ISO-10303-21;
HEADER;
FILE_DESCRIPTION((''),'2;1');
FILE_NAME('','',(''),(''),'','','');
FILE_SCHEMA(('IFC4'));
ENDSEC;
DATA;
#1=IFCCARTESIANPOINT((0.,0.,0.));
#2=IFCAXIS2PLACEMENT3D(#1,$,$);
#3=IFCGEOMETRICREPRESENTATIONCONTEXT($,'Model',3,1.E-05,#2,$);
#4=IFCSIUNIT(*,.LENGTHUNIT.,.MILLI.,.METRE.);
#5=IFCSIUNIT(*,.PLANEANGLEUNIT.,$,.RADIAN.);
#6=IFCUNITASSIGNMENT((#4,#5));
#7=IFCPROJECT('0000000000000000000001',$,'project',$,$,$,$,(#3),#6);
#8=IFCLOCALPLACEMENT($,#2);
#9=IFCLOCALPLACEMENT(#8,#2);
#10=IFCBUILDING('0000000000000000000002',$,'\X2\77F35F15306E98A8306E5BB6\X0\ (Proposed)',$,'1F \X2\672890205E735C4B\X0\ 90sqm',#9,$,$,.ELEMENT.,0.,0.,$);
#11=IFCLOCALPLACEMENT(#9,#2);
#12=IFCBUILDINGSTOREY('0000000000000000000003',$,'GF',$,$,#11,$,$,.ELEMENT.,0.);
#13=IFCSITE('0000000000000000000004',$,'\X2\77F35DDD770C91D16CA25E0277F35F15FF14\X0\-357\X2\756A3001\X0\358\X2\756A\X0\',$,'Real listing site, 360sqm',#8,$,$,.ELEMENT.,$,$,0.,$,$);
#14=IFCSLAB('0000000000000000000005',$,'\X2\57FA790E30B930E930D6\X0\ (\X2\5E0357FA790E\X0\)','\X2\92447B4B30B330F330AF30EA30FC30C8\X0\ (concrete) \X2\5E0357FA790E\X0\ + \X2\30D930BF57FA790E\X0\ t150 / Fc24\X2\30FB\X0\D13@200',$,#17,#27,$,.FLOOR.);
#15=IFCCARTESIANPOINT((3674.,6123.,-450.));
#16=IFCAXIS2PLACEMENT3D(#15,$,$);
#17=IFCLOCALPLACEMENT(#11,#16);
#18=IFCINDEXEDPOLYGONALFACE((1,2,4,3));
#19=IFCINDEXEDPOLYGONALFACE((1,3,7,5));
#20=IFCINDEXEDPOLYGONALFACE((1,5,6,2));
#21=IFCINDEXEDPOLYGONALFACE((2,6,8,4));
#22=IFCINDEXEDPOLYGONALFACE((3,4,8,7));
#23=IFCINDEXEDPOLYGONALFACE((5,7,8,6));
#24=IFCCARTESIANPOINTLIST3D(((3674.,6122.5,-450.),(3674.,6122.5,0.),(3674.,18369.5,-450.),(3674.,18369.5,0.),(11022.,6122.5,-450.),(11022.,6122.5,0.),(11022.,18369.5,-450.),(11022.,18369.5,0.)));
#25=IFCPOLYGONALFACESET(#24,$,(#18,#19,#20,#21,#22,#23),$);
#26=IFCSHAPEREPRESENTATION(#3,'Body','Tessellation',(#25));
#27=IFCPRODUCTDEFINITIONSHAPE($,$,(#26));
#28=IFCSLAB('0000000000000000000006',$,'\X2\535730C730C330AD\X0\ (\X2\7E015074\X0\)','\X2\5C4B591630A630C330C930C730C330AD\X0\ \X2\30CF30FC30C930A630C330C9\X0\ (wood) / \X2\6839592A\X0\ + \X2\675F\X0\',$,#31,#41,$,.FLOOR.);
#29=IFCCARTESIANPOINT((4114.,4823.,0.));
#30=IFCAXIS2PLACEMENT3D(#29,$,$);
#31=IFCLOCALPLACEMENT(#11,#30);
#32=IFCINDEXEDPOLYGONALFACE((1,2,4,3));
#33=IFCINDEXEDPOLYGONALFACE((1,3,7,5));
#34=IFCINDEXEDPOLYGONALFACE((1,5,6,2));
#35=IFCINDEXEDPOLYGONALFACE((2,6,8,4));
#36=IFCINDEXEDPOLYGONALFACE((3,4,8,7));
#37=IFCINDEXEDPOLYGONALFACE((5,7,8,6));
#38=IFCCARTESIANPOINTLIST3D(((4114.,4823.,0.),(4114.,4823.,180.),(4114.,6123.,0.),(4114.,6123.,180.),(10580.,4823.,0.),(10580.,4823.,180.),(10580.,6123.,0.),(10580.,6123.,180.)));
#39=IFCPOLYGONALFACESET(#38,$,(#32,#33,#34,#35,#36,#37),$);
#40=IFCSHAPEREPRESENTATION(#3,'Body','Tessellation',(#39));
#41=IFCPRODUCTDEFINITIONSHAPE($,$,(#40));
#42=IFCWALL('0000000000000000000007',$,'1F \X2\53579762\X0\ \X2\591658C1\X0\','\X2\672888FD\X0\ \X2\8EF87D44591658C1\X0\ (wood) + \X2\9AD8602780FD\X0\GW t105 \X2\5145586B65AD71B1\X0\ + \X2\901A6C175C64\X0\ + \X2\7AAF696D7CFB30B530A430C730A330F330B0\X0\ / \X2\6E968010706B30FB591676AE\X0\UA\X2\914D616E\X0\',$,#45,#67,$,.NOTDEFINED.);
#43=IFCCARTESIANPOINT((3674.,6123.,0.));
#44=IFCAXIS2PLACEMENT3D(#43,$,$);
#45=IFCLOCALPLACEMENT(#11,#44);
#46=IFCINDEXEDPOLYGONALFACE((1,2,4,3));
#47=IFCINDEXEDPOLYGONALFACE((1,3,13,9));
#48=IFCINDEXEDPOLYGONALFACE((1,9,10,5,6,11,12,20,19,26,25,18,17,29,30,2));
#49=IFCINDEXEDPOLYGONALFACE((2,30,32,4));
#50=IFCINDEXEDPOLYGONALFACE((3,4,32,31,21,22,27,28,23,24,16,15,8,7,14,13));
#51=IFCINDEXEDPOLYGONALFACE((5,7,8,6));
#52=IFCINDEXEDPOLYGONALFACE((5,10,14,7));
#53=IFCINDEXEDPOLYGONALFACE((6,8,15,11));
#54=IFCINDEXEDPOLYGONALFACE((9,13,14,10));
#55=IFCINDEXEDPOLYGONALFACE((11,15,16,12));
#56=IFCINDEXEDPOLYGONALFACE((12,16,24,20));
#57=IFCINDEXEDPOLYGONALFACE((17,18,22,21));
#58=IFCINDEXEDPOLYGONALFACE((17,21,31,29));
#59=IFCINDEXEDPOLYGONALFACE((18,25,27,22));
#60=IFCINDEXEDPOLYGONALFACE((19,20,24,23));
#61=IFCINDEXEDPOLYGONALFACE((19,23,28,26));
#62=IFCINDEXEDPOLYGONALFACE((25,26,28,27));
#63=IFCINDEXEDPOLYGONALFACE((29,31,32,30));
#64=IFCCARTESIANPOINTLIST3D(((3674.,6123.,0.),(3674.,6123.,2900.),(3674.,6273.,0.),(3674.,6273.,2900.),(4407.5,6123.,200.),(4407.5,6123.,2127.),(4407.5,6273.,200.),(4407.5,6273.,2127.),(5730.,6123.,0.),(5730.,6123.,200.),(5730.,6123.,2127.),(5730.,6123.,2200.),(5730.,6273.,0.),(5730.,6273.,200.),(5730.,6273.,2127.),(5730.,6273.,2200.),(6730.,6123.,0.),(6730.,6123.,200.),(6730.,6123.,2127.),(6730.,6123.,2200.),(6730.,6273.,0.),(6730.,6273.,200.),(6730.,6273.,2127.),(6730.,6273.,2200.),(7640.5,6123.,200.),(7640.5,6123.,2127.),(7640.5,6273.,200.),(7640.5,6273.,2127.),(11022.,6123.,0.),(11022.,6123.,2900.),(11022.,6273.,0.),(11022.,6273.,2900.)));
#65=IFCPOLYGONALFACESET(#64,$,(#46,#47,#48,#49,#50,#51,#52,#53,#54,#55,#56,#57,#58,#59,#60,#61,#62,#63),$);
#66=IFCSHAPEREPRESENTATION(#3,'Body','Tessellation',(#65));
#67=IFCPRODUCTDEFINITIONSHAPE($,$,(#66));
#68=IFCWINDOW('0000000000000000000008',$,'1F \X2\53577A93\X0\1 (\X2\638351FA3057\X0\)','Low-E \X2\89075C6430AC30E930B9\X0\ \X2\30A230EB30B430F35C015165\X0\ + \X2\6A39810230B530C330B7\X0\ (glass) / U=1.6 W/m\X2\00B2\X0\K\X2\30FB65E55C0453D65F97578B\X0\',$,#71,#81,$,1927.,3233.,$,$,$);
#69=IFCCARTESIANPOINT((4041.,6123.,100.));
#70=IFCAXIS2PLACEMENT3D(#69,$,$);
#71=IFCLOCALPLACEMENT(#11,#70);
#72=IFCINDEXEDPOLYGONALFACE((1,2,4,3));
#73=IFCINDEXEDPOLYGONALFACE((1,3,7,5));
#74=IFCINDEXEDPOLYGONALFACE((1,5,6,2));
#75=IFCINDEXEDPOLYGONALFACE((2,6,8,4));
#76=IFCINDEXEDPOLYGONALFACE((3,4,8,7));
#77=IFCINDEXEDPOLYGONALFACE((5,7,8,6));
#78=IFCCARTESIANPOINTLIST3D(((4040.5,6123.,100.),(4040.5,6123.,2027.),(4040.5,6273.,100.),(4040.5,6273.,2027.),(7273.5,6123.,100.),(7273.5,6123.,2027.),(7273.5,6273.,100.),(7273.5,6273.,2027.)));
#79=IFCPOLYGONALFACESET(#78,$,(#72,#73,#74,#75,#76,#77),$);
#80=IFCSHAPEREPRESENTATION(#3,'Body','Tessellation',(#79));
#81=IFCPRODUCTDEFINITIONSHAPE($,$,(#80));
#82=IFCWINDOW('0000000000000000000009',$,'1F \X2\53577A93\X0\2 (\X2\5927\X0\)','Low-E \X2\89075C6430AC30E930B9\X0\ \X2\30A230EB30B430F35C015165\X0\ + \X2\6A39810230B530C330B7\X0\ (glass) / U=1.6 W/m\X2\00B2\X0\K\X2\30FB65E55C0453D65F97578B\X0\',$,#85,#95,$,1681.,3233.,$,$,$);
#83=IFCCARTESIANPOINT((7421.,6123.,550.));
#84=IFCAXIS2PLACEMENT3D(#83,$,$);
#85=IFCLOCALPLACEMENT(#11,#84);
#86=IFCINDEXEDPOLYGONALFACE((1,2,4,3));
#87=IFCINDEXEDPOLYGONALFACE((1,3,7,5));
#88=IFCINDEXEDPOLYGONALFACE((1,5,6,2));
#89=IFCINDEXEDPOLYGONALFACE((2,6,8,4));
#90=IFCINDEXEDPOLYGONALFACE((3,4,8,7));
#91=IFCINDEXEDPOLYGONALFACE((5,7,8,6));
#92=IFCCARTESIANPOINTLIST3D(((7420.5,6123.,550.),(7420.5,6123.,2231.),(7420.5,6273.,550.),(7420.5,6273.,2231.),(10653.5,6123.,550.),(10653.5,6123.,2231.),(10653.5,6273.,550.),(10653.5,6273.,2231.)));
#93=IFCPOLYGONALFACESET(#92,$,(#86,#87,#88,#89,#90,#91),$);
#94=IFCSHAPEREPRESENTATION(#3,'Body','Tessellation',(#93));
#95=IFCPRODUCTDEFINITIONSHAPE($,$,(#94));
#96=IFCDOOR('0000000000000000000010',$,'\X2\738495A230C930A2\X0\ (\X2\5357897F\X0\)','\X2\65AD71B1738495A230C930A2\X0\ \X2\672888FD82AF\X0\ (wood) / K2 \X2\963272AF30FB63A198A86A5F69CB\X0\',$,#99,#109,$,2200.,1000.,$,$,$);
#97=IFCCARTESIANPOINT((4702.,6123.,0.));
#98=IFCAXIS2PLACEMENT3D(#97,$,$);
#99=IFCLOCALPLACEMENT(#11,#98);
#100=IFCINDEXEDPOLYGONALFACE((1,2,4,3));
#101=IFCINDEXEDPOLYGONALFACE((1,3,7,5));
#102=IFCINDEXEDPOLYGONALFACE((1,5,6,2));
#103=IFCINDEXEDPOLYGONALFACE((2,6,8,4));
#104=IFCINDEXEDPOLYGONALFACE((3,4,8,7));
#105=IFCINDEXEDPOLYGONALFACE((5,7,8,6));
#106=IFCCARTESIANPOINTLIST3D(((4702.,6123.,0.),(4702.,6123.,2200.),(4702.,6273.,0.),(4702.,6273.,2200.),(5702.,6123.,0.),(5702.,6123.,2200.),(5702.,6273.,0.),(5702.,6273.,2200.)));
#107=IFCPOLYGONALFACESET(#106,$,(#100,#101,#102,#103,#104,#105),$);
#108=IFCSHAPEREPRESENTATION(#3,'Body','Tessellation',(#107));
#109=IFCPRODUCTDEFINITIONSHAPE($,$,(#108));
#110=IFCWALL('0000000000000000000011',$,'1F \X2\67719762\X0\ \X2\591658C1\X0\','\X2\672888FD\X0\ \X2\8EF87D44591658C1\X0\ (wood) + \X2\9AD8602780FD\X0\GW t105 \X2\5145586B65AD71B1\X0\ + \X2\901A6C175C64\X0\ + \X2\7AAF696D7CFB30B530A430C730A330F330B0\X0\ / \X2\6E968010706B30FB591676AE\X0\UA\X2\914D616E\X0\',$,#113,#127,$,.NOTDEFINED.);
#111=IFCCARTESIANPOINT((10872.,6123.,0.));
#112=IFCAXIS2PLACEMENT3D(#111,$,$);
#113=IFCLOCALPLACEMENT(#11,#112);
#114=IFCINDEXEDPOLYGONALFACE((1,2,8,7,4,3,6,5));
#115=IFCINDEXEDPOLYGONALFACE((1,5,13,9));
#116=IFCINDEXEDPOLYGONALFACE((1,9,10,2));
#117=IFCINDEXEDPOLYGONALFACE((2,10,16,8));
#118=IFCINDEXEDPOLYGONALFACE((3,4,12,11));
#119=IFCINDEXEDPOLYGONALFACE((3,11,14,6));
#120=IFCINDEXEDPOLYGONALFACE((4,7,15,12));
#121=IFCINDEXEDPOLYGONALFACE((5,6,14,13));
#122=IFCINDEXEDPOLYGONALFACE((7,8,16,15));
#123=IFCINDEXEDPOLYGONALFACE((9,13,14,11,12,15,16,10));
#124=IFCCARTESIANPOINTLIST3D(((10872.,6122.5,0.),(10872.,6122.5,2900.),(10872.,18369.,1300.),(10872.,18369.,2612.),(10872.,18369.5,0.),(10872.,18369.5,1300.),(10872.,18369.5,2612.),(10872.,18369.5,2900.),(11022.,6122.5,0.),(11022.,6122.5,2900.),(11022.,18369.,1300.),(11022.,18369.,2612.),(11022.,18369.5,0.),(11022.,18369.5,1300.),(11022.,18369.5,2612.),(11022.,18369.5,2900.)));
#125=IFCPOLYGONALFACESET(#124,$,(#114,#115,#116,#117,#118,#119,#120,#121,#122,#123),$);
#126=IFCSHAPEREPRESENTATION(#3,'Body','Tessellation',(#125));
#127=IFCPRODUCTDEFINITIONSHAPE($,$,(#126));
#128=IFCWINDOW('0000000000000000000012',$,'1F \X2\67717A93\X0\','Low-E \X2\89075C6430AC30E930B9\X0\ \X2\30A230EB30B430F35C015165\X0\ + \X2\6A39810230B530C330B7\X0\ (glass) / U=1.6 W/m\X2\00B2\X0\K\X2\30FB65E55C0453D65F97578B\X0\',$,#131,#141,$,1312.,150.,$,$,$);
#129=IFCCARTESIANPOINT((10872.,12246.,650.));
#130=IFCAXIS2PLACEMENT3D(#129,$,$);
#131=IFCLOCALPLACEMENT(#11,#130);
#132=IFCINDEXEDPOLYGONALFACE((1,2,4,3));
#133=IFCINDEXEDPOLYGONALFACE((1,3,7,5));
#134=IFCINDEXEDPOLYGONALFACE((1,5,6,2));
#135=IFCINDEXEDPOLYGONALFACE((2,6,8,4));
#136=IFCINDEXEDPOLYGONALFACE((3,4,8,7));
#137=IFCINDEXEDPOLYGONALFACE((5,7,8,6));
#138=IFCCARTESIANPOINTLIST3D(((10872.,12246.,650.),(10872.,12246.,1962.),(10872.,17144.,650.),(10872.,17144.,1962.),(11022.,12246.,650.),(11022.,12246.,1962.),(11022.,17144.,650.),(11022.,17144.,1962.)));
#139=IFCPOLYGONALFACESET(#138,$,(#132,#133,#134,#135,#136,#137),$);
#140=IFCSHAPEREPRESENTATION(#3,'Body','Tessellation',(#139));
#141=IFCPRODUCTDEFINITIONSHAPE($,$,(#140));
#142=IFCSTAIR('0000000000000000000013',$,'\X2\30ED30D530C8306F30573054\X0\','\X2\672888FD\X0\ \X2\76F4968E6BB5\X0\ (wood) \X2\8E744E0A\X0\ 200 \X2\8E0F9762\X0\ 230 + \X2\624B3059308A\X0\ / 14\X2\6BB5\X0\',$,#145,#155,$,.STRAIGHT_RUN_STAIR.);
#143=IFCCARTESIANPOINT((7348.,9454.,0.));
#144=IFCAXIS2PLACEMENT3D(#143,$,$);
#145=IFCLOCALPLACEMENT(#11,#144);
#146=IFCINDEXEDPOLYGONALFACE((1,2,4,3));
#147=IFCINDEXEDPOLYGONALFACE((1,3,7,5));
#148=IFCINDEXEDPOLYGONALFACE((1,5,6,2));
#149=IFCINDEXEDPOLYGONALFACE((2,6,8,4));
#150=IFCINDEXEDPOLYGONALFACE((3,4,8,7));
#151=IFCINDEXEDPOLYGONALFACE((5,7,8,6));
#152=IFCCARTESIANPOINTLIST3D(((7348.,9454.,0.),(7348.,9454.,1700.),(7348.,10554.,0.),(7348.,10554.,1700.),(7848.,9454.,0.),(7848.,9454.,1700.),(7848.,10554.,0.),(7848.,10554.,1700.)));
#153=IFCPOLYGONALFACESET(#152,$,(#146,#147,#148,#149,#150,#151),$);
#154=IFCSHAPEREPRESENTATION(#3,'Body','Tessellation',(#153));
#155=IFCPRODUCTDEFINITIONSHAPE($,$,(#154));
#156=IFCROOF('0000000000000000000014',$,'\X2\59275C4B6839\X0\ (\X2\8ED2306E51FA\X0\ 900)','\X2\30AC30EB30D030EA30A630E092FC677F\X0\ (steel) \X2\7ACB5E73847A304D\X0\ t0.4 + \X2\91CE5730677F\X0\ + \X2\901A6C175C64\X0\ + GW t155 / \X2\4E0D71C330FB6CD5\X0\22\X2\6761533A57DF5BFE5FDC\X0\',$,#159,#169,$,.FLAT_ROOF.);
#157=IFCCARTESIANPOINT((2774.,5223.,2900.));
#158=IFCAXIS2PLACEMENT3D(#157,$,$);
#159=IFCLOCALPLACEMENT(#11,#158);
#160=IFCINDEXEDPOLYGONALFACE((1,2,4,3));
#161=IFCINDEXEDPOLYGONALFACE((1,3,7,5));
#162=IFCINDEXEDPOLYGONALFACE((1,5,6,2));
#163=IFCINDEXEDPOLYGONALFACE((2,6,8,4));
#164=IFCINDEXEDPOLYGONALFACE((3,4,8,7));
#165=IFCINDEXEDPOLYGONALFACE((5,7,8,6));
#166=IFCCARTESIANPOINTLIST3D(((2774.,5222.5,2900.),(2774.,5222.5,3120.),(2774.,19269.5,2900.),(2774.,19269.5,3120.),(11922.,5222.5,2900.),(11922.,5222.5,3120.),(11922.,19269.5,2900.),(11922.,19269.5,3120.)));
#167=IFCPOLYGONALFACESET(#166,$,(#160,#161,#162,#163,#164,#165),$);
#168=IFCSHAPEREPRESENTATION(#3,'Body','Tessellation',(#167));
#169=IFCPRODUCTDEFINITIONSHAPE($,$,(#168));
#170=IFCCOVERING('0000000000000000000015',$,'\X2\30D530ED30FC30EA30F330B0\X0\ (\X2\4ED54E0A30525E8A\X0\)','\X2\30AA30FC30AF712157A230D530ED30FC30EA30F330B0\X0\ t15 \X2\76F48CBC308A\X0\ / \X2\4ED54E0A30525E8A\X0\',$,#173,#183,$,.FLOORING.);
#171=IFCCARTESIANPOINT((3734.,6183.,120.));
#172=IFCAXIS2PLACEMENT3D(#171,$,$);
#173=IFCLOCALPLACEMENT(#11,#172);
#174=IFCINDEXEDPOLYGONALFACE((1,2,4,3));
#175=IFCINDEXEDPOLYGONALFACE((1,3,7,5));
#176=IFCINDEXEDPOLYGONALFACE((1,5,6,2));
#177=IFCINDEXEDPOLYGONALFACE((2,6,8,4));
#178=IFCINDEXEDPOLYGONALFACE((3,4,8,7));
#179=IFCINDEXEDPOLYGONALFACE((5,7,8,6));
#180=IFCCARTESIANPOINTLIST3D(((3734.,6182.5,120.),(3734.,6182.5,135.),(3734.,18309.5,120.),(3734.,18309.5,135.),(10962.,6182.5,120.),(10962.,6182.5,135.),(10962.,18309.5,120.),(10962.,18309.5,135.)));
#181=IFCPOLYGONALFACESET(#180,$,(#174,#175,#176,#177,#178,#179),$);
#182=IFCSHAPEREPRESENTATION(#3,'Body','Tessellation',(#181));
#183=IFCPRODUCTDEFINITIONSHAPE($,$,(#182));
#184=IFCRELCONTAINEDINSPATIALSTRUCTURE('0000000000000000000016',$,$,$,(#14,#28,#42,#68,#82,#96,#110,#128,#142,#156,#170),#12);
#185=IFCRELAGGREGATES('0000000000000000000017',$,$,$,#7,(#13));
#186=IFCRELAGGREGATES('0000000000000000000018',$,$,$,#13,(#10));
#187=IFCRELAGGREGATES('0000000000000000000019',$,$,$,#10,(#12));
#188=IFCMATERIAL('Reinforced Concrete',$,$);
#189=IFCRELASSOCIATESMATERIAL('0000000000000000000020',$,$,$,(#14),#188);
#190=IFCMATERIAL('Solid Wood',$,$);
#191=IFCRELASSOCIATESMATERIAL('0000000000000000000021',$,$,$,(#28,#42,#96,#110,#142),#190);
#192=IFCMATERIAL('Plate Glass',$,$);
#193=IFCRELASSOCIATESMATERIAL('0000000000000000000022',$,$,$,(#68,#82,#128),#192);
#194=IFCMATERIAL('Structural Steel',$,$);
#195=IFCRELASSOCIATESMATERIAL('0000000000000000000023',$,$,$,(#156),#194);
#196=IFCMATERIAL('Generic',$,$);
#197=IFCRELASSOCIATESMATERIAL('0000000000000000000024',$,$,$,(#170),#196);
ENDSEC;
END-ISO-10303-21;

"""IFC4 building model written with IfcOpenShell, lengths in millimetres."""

from ifc_helpers import new_model, si_unit, frame, frame_2d, origin, place, context, project, spatial, rectangle, extrude, material, element, fill, save


model = new_model("IFC4")

# Units and contexts
model_context = context("Model", 3, precision=1e-05, world=origin())
ifc_project = project(units=[si_unit("LENGTHUNIT", "METRE", prefix="MILLI"), si_unit("PLANEANGLEUNIT", "RADIAN")], contexts=[model_context])

# Site, building, storey
site_placement = place(None, origin())
site = spatial("IfcSite", under=ifc_project, at=site_placement, Name="石川県金沢市石引４-357番、358番", ObjectType="Real listing site, 360sqm", CompositionType="ELEMENT", RefElevation=0.0)
building_placement = place(site_placement, origin())
building = spatial("IfcBuilding", under=site, at=building_placement, Name="石引の風の家 (Proposed)", ObjectType="1F 木造平屋 90sqm", CompositionType="ELEMENT", ElevationOfRefHeight=0.0, ElevationOfTerrain=0.0)
storey_placement = place(building_placement, origin())
storey = spatial("IfcBuildingStorey", under=building, at=storey_placement, Name="GF", CompositionType="ELEMENT", Elevation=0.0)

# Slabs
ifc_material_1 = material(Name="Reinforced Concrete")
slab_1_placement = place(storey_placement, frame((3674.0, 6123.0, -450.0)))
element("IfcSlab", 1, at=slab_1_placement, inside=storey, material=ifc_material_1, Name="基礎スラブ (布基礎)", Description="鉄筋コンクリート (concrete) 布基礎 + ベタ基礎 t150 / Fc24・D13@200", PredefinedType="FLOOR", context=model_context, shape_type="SweptSolid", body=[
    extrude(rectangle(XDim=7348.0, YDim=12247.0, at=frame_2d((3674.0, 6123.0))), frame((3674.0, 6123.0, -450.0)), (0.0, 0.0, 1.0), 450.0),
])
ifc_material_2 = material(Name="Solid Wood")
slab_2_placement = place(storey_placement, frame((4114.0, 4823.0, 0.0)))
element("IfcSlab", 2, at=slab_2_placement, inside=storey, material=ifc_material_2, Name="南デッキ (縁側)", Description="屋外ウッドデッキ ハードウッド (wood) / 根太 + 束", PredefinedType="FLOOR", context=model_context, shape_type="SweptSolid", body=[
    extrude(rectangle(XDim=6466.0, YDim=1300.0, at=frame_2d((3233.0, 650.0))), frame((4114.0, 4823.0, 0.0)), (0.0, 0.0, 1.0), 180.0),
])

# Wall, openings, windows, door
wall_1_placement = place(storey_placement, frame((3674.0, 6123.0, 0.0)))
wall_1 = element("IfcWall", 3, at=wall_1_placement, inside=storey, material=ifc_material_2, Name="1F 南面 外壁", Description="木製 軸組外壁 (wood) + 高性能GW t105 充填断熱 + 通気層 + 窯業系サイディング / 準耐火・外皮UA配慮", PredefinedType="NOTDEFINED", context=model_context, shape_type="SweptSolid", body=[
    extrude(rectangle(XDim=7348.0, YDim=150.0, at=frame_2d((3674.0, 75.0))), frame((3674.0, 6123.0, 0.0)), (0.0, 0.0, 1.0), 2900.0),
])
opening_1_placement = place(storey_placement, frame((4041.0, 6123.0, 100.0)))
opening_1 = element("IfcOpeningElement", 4, at=opening_1_placement, cuts=wall_1, PredefinedType="NOTDEFINED", context=model_context, shape_type="SweptSolid", body=[
    extrude(rectangle(XDim=3233.0, YDim=150.0, at=frame_2d((1616.0, 75.0))), frame((4041.0, 6123.0, 100.0)), (0.0, 0.0, 1.0), 1927.0),
])
opening_2_placement = place(storey_placement, frame((7421.0, 6123.0, 550.0)))
opening_2 = element("IfcOpeningElement", 5, at=opening_2_placement, cuts=wall_1, PredefinedType="NOTDEFINED", context=model_context, shape_type="SweptSolid", body=[
    extrude(rectangle(XDim=3233.0, YDim=150.0, at=frame_2d((1616.0, 75.0))), frame((7421.0, 6123.0, 550.0)), (0.0, 0.0, 1.0), 1681.0),
])
opening_3_placement = place(storey_placement, frame((4702.0, 6123.0, 0.0)))
opening_3 = element("IfcOpeningElement", 6, at=opening_3_placement, cuts=wall_1, PredefinedType="NOTDEFINED", context=model_context, shape_type="SweptSolid", body=[
    extrude(rectangle(XDim=1000.0, YDim=150.0, at=frame_2d((500.0, 75.0))), frame((4702.0, 6123.0, 0.0)), (0.0, 0.0, 1.0), 2200.0),
])
ifc_material_3 = material(Name="Plate Glass")
window_1_placement = place(storey_placement, frame((4041.0, 6123.0, 100.0)))
window_1 = element("IfcWindow", 7, at=window_1_placement, inside=storey, material=ifc_material_3, Name="1F 南窓1 (掃出し)", Description="Low-E 複層ガラス アルゴン封入 + 樹脂サッシ (glass) / U=1.6 W/m²K・日射取得型", OverallHeight=1927.0, OverallWidth=3233.0, context=model_context, shape_type="SweptSolid", body=[
    extrude(rectangle(XDim=3233.0, YDim=150.0, at=frame_2d((1616.0, 75.0))), frame((4041.0, 6123.0, 100.0)), (0.0, 0.0, 1.0), 1927.0),
])
fill(opening_1, window_1)
window_2_placement = place(storey_placement, frame((7421.0, 6123.0, 550.0)))
window_2 = element("IfcWindow", 8, at=window_2_placement, inside=storey, material=ifc_material_3, Name="1F 南窓2 (大)", Description="Low-E 複層ガラス アルゴン封入 + 樹脂サッシ (glass) / U=1.6 W/m²K・日射取得型", OverallHeight=1681.0, OverallWidth=3233.0, context=model_context, shape_type="SweptSolid", body=[
    extrude(rectangle(XDim=3233.0, YDim=150.0, at=frame_2d((1616.0, 75.0))), frame((7421.0, 6123.0, 550.0)), (0.0, 0.0, 1.0), 1681.0),
])
fill(opening_2, window_2)
door_placement = place(storey_placement, frame((4702.0, 6123.0, 0.0)))
door = element("IfcDoor", 9, at=door_placement, inside=storey, material=ifc_material_2, Name="玄関ドア (南西)", Description="断熱玄関ドア 木製芯 (wood) / K2 防犯・採風機構", OverallHeight=2200.0, OverallWidth=1000.0, context=model_context, shape_type="SweptSolid", body=[
    extrude(rectangle(XDim=1000.0, YDim=150.0, at=frame_2d((500.0, 75.0))), frame((4702.0, 6123.0, 0.0)), (0.0, 0.0, 1.0), 2200.0),
])
fill(opening_3, door)

# Wall, opening, window
wall_2_placement = place(storey_placement, frame((10872.0, 6123.0, 0.0)))
wall_2 = element("IfcWall", 10, at=wall_2_placement, inside=storey, material=ifc_material_2, Name="1F 東面 外壁", Description="木製 軸組外壁 (wood) + 高性能GW t105 充填断熱 + 通気層 + 窯業系サイディング / 準耐火・外皮UA配慮", PredefinedType="NOTDEFINED", context=model_context, shape_type="SweptSolid", body=[
    extrude(rectangle(XDim=150.0, YDim=12247.0, at=frame_2d((75.0, 6123.0))), frame((10872.0, 6123.0, 0.0)), (0.0, 0.0, 1.0), 2900.0),
])
opening_4_placement = place(storey_placement, frame((10872.0, 12246.0, 650.0)))
opening_4 = element("IfcOpeningElement", 11, at=opening_4_placement, cuts=wall_2, PredefinedType="NOTDEFINED", context=model_context, shape_type="SweptSolid", body=[
    extrude(rectangle(XDim=150.0, YDim=4898.0, at=frame_2d((75.0, 2449.0))), frame((10872.0, 12246.0, 650.0)), (0.0, 0.0, 1.0), 1312.0),
])
window_3_placement = place(storey_placement, frame((10872.0, 12246.0, 650.0)))
window_3 = element("IfcWindow", 12, at=window_3_placement, inside=storey, material=ifc_material_3, Name="1F 東窓", Description="Low-E 複層ガラス アルゴン封入 + 樹脂サッシ (glass) / U=1.6 W/m²K・日射取得型", OverallHeight=1312.0, OverallWidth=150.0, context=model_context, shape_type="SweptSolid", body=[
    extrude(rectangle(XDim=150.0, YDim=4898.0, at=frame_2d((75.0, 2449.0))), frame((10872.0, 12246.0, 650.0)), (0.0, 0.0, 1.0), 1312.0),
])
fill(opening_4, window_3)

# Stair
stair_placement = place(storey_placement, frame((7348.0, 9454.0, 0.0)))
element("IfcStair", 13, at=stair_placement, inside=storey, material=ifc_material_2, Name="ロフトはしご", Description="木製 直階段 (wood) 蹴上 200 踏面 230 + 手すり / 14段", PredefinedType="STRAIGHT_RUN_STAIR", context=model_context, shape_type="SweptSolid", body=[
    extrude(rectangle(XDim=500.0, YDim=1100.0, at=frame_2d((250.0, 550.0))), frame((7348.0, 9454.0, 0.0)), (0.0, 0.0, 1.0), 1700.0),
])

# Roof
ifc_material_4 = material(Name="Structural Steel")
roof_placement = place(storey_placement, frame((2774.0, 5223.0, 2900.0)))
element("IfcRoof", 14, at=roof_placement, inside=storey, material=ifc_material_4, Name="大屋根 (軒の出 900)", Description="ガルバリウム鋼板 (steel) 立平葺き t0.4 + 野地板 + 通気層 + GW t155 / 不燃・法22条区域対応", PredefinedType="FLAT_ROOF", context=model_context, shape_type="SweptSolid", body=[
    extrude(rectangle(XDim=9148.0, YDim=14047.0, at=frame_2d((4574.0, 7023.0))), frame((2774.0, 5223.0, 2900.0)), (0.0, 0.0, 1.0), 220.0),
])

# Covering
ifc_material_5 = material(Name="Generic")
covering_placement = place(storey_placement, frame((3734.0, 6183.0, 120.0)))
element("IfcCovering", 15, at=covering_placement, inside=storey, material=ifc_material_5, Name="フローリング (仕上げ床)", Description="オーク無垢フローリング t15 直貼り / 仕上げ床", PredefinedType="FLOORING", context=model_context, shape_type="SweptSolid", body=[
    extrude(rectangle(XDim=7228.0, YDim=12127.0, at=frame_2d((3614.0, 6063.0))), frame((3734.0, 6183.0, 120.0)), (0.0, 0.0, 1.0), 15.0),
])

save(model, "model.ifc")
